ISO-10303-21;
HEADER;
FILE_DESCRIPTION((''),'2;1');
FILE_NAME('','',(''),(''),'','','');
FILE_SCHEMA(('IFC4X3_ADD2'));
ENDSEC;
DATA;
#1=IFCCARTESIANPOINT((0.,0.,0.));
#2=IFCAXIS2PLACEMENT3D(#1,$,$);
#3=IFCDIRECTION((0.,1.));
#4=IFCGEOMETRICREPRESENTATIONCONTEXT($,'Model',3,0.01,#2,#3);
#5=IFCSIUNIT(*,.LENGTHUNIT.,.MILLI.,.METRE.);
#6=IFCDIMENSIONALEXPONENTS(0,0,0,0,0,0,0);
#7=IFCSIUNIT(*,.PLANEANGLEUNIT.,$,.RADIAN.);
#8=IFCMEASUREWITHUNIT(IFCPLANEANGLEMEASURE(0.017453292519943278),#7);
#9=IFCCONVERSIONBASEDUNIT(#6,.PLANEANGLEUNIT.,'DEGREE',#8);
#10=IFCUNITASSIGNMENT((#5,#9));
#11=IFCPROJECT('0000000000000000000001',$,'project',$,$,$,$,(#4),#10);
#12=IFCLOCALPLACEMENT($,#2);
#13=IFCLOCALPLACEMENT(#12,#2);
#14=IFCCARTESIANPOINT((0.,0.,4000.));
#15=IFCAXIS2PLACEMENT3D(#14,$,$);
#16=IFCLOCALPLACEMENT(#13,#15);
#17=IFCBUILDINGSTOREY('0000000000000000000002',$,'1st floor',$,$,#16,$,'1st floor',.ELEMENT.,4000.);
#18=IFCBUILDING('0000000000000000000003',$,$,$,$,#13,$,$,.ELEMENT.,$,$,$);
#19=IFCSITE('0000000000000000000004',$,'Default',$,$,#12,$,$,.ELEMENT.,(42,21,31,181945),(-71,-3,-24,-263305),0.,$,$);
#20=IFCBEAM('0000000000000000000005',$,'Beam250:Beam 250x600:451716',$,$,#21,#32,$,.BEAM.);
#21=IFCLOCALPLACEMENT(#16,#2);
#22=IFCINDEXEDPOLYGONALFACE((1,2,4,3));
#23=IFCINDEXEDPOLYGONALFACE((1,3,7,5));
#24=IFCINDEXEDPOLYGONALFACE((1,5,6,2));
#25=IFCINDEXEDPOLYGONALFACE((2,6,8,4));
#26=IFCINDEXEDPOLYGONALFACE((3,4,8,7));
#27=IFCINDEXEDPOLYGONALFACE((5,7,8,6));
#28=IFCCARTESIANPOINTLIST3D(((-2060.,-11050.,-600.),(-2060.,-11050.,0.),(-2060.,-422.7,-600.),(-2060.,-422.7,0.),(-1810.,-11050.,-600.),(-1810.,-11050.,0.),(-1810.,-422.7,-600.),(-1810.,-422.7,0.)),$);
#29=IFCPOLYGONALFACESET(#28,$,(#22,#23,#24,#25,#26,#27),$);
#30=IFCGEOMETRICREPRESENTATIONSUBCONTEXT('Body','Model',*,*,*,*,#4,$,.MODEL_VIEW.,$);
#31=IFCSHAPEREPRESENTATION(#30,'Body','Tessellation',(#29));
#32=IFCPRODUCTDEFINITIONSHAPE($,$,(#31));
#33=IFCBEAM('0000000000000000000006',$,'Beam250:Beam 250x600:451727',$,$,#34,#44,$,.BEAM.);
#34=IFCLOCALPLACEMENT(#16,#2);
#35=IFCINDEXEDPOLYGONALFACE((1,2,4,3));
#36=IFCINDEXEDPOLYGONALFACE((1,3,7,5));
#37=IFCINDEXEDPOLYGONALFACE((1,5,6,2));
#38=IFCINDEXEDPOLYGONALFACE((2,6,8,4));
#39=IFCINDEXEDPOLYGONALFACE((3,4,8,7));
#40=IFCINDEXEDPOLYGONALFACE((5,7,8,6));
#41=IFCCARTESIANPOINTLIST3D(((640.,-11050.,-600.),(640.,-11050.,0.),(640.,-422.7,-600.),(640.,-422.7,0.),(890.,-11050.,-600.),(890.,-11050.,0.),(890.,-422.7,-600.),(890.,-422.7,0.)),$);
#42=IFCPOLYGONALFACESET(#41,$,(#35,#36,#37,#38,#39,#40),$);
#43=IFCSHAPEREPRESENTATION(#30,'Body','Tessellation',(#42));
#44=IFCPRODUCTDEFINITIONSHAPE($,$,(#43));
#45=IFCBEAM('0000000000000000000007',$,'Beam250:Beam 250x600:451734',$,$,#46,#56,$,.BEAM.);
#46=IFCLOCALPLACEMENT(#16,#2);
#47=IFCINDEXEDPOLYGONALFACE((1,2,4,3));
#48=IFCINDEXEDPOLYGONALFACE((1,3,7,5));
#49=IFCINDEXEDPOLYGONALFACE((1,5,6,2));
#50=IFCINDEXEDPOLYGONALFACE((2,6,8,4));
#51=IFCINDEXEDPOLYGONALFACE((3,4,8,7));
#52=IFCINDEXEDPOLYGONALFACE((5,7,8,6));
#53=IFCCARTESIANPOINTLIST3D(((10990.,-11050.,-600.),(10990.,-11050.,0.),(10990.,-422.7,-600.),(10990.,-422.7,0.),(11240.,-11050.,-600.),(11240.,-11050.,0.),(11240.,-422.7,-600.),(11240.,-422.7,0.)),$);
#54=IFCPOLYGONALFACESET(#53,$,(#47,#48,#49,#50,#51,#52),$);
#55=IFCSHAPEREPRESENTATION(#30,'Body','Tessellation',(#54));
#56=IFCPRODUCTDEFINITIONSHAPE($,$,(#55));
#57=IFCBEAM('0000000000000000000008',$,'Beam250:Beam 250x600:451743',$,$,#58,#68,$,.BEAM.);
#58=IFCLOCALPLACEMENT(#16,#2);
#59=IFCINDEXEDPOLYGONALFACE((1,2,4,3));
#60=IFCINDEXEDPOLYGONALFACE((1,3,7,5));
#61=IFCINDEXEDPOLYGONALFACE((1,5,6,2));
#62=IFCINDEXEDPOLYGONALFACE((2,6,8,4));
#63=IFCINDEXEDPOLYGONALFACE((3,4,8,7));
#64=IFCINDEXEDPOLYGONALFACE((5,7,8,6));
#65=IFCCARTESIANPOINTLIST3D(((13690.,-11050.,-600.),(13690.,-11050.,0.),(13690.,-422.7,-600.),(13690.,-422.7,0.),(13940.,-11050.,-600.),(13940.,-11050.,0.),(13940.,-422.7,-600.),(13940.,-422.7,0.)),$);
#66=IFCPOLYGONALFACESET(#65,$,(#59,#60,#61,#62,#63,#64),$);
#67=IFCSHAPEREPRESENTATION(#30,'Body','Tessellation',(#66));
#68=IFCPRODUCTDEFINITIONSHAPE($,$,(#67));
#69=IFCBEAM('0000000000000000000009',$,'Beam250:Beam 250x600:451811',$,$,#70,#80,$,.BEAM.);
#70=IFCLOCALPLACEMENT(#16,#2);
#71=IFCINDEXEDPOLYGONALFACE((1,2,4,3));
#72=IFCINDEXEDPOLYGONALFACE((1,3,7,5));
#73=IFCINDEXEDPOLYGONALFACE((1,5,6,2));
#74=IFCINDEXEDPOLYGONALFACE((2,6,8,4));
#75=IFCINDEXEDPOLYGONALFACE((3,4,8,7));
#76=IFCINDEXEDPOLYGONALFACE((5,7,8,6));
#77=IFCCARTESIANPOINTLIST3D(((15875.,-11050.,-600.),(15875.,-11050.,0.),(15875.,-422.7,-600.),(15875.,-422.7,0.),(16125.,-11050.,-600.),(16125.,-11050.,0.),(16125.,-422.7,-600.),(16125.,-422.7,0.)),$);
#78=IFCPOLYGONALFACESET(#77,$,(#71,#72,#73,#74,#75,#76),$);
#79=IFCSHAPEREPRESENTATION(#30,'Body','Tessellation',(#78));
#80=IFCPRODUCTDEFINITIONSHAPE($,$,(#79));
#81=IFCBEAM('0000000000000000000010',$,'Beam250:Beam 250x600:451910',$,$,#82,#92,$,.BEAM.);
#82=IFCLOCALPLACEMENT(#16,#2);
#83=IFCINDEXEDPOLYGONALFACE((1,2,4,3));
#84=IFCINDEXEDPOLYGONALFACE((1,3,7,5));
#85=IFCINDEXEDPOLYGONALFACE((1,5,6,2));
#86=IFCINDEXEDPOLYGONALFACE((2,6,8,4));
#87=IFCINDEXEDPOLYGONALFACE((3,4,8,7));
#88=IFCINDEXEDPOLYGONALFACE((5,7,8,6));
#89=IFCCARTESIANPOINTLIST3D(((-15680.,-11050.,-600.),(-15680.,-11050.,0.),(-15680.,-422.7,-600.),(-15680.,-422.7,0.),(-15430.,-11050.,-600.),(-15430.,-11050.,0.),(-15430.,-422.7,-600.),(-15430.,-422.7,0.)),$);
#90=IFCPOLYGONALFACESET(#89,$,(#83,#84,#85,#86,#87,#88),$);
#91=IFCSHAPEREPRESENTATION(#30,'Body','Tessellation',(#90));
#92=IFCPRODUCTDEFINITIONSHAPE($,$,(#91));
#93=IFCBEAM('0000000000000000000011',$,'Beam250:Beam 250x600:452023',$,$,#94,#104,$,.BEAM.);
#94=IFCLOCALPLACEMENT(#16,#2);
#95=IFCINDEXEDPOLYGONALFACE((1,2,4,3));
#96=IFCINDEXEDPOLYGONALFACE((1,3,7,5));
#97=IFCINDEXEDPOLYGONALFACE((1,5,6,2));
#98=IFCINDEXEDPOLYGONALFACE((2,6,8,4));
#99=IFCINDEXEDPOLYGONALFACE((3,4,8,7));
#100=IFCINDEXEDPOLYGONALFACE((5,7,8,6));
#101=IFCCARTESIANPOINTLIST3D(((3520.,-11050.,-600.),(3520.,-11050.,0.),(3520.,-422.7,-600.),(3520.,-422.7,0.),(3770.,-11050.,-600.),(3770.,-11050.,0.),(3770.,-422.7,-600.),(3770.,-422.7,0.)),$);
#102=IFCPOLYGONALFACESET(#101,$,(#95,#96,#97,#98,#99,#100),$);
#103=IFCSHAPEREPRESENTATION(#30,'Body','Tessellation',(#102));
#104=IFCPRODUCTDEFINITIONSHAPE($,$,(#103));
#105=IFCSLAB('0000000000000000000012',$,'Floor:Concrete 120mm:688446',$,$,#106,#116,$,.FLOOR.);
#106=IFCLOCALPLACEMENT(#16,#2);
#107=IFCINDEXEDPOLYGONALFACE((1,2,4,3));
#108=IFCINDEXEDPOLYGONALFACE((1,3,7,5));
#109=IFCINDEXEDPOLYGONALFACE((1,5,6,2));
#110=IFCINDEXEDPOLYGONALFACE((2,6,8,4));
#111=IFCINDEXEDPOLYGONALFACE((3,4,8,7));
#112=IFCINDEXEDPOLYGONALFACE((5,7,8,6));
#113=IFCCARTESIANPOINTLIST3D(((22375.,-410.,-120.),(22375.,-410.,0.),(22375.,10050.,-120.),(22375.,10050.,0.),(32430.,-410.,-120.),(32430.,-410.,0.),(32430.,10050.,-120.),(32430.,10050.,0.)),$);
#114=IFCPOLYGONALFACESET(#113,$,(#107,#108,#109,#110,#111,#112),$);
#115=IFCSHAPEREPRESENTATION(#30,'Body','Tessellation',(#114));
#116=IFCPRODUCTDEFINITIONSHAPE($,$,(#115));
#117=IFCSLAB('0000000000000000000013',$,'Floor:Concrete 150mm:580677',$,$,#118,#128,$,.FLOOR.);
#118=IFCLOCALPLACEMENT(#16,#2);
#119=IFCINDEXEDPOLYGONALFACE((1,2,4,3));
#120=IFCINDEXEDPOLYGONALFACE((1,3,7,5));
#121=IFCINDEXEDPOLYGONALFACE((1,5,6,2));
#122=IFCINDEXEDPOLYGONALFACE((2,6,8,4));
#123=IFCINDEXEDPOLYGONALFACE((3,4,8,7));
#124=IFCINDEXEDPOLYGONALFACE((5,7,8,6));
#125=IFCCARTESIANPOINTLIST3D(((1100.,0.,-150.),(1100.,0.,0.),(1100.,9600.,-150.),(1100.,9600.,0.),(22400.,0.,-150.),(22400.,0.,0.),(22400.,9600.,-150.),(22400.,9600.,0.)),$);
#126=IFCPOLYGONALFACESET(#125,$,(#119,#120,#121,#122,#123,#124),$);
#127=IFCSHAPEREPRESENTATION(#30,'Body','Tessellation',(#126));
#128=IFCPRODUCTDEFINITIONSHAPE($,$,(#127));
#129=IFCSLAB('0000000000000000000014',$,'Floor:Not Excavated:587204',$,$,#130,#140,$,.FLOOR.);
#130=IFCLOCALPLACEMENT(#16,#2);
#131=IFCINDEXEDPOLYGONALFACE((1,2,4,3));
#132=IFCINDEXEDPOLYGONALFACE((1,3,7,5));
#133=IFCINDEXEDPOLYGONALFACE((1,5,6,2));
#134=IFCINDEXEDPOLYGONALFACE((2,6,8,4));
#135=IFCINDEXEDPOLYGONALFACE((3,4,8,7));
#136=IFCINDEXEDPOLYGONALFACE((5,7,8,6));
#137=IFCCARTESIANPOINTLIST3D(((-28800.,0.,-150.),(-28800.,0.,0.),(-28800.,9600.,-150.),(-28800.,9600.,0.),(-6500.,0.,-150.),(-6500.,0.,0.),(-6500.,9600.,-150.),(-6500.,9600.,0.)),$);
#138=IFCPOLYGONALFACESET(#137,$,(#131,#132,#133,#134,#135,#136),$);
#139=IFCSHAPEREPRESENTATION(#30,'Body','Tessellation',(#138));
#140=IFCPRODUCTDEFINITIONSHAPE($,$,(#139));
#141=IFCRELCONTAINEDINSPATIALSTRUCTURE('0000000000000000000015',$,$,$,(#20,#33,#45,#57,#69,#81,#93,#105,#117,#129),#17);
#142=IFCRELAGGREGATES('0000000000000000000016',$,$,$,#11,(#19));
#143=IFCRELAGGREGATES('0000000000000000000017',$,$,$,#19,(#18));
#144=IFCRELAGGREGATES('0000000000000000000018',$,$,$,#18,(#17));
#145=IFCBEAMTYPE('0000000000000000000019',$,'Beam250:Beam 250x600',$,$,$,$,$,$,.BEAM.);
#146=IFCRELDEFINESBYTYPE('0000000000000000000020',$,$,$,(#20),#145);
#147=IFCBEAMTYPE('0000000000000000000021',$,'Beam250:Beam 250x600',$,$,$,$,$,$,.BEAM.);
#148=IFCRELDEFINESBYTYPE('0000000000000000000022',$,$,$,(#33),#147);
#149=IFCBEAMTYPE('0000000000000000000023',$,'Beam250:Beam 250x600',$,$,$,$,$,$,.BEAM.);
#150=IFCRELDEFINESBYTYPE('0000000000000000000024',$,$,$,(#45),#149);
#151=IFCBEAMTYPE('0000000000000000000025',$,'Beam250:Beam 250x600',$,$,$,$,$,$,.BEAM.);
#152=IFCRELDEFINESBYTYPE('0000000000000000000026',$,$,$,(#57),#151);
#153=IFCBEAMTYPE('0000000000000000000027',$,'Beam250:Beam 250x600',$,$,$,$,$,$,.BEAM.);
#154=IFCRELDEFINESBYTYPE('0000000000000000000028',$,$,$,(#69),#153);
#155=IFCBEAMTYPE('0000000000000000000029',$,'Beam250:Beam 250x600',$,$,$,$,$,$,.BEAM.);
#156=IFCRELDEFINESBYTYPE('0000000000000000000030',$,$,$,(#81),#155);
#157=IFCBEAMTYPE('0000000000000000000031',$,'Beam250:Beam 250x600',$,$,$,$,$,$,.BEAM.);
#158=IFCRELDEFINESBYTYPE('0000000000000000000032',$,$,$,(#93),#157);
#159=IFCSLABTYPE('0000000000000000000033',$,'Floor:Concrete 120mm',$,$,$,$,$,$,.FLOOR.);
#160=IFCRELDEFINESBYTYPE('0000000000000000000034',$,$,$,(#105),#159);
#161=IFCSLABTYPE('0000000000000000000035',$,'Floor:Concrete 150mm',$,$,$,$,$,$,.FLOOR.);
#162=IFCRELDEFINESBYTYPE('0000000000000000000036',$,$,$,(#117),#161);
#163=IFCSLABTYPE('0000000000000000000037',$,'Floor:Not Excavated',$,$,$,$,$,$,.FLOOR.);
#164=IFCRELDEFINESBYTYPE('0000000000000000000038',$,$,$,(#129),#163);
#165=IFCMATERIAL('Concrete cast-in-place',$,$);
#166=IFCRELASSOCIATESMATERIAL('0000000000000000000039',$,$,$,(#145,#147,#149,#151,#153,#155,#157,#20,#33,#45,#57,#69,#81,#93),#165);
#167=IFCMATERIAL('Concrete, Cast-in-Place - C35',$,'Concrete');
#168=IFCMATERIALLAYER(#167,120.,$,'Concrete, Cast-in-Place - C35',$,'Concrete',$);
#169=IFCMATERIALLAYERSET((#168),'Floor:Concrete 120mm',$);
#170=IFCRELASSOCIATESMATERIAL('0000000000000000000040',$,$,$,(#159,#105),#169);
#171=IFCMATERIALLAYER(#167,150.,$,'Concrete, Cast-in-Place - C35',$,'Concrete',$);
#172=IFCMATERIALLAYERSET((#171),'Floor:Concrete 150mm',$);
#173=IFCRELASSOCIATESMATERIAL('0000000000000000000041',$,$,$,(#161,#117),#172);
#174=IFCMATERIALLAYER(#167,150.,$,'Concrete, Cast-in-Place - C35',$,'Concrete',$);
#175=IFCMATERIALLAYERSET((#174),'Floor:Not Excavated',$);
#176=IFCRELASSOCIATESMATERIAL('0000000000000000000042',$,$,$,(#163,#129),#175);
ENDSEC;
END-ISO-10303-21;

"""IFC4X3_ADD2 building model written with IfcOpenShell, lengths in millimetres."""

from ifc_helpers import new_model, entity, si_unit, converted_unit, direction, frame, frame_2d, origin, origin_2d_with_axis, place, context, subcontext, project, spatial, rectangle, extrude, source, transform, mapped, material, layer, layer_set, layer_usage, material_profile, profile_set, profile_usage, type_object, type_shapes, element, save


model = new_model("IFC4X3_ADD2")

# Units and contexts
model_context = context("Model", 3, precision=0.01, world=origin(), true_north=direction((0.0, 1.0)))
body_context = subcontext(model_context, "Body", "Model", "MODEL_VIEW")
ifc_project = project(units=[si_unit("LENGTHUNIT", "METRE", prefix="MILLI"), converted_unit("PLANEANGLEUNIT", "DEGREE", entity("IfcPlaneAngleMeasure", 0.017453292519943278), si_unit("PLANEANGLEUNIT", "RADIAN"), dimensions=[0, 0, 0, 0, 0, 0, 0])], contexts=[model_context])

# Site, building, storey
site_placement = place(None, origin())
site = spatial("IfcSite", under=ifc_project, at=site_placement, Name="Default", CompositionType="ELEMENT", RefLatitude=(42, 21, 31, 181945), RefLongitude=(-71, -3, -24, -263305), RefElevation=0.0)
building_placement = place(site_placement, origin())
building = spatial("IfcBuilding", under=site, at=building_placement, CompositionType="ELEMENT")
storey_placement = place(building_placement, frame((0.0, 0.0, 4000.0)))
storey = spatial("IfcBuildingStorey", under=building, at=storey_placement, Name="1st floor", LongName="1st floor", CompositionType="ELEMENT", Elevation=4000.0)

# Shared definitions
ifc_material_1 = material(Name="Concrete, Cast-in-Place - C35", Category="Concrete")

# Beams
ifc_material_2 = material(Name="Concrete cast-in-place")
ifc_material_profile_1 = material_profile(ifc_material_2, rectangle(XDim=600.0, YDim=250.0, at=frame_2d((0.0, 0.0), x_axis=(0.0, 1.0))), Name="Beam 250x600")
ifc_profile_set_1 = profile_set([ifc_material_profile_1], Name="Beam 250x600")
ifc_profile_usage_1 = profile_usage(ifc_profile_set_1, cardinal=8)
beam_type_1 = type_object("IfcBeamType", Name="Beam250:Beam 250x600", PredefinedType="BEAM", material=ifc_profile_set_1)
shared_shape_1 = source(origin(), body_context, "Body", "SweptSolid", [
    extrude(rectangle(XDim=600.0, YDim=250.0, at=frame_2d((0.0, 0.0), x_axis=(0.0, 1.0))), frame((-1935.0, -11050.0, 3700.0), z_axis=(0.0, 1.0, 0.0), x_axis=(-1.0, 0.0, 0.0)), (0.0, 0.0, 1.0), 10627.3),
])
type_shapes(beam_type_1, [shared_shape_1])
beam_1_placement = place(storey_placement, frame((0.0, 0.0, -4000.0)))
element("IfcBeam", 1, at=beam_1_placement, inside=storey, type_object=beam_type_1, material=ifc_profile_usage_1, Name="Beam250:Beam 250x600:451716", PredefinedType="BEAM", context=body_context, shape_type="MappedRepresentation", body=[
    mapped(shared_shape_1, transform((0.0, 0.0, 0.0), scale=1.0)),
])
beam_type_2 = type_object("IfcBeamType", Name="Beam250:Beam 250x600", PredefinedType="BEAM", material=ifc_profile_set_1)
shared_shape_2 = source(origin(), body_context, "Body", "SweptSolid", [
    extrude(rectangle(XDim=600.0, YDim=250.0, at=frame_2d((0.0, 0.0), x_axis=(0.0, 1.0))), frame((765.0, -11050.0, 3700.0), z_axis=(0.0, 1.0, 0.0), x_axis=(-1.0, 0.0, 0.0)), (0.0, 0.0, 1.0), 10627.3),
])
type_shapes(beam_type_2, [shared_shape_2])
beam_2_placement = place(storey_placement, frame((0.0, 0.0, -4000.0)))
element("IfcBeam", 2, at=beam_2_placement, inside=storey, type_object=beam_type_2, material=ifc_profile_usage_1, Name="Beam250:Beam 250x600:451727", PredefinedType="BEAM", context=body_context, shape_type="MappedRepresentation", body=[
    mapped(shared_shape_2, transform((0.0, 0.0, 0.0), scale=1.0)),
])
beam_type_3 = type_object("IfcBeamType", Name="Beam250:Beam 250x600", PredefinedType="BEAM", material=ifc_profile_set_1)
shared_shape_3 = source(origin(), body_context, "Body", "SweptSolid", [
    extrude(rectangle(XDim=600.0, YDim=250.0, at=frame_2d((0.0, 0.0), x_axis=(0.0, 1.0))), frame((11115.0, -11050.0, 3700.0), z_axis=(0.0, 1.0, 0.0), x_axis=(-1.0, 0.0, 0.0)), (0.0, 0.0, 1.0), 10627.3),
])
type_shapes(beam_type_3, [shared_shape_3])
beam_3_placement = place(storey_placement, frame((0.0, 0.0, -4000.0)))
element("IfcBeam", 3, at=beam_3_placement, inside=storey, type_object=beam_type_3, material=ifc_profile_usage_1, Name="Beam250:Beam 250x600:451734", PredefinedType="BEAM", context=body_context, shape_type="MappedRepresentation", body=[
    mapped(shared_shape_3, transform((0.0, 0.0, 0.0), scale=1.0)),
])
beam_type_4 = type_object("IfcBeamType", Name="Beam250:Beam 250x600", PredefinedType="BEAM", material=ifc_profile_set_1)
shared_shape_4 = source(origin(), body_context, "Body", "SweptSolid", [
    extrude(rectangle(XDim=600.0, YDim=250.0, at=frame_2d((0.0, 0.0), x_axis=(0.0, 1.0))), frame((13815.0, -11050.0, 3700.0), z_axis=(0.0, 1.0, 0.0), x_axis=(-1.0, 0.0, 0.0)), (0.0, 0.0, 1.0), 10627.3),
])
type_shapes(beam_type_4, [shared_shape_4])
beam_4_placement = place(storey_placement, frame((0.0, 0.0, -4000.0)))
element("IfcBeam", 4, at=beam_4_placement, inside=storey, type_object=beam_type_4, material=ifc_profile_usage_1, Name="Beam250:Beam 250x600:451743", PredefinedType="BEAM", context=body_context, shape_type="MappedRepresentation", body=[
    mapped(shared_shape_4, transform((0.0, 0.0, 0.0), scale=1.0)),
])
beam_type_5 = type_object("IfcBeamType", Name="Beam250:Beam 250x600", PredefinedType="BEAM", material=ifc_profile_set_1)
shared_shape_5 = source(origin(), body_context, "Body", "SweptSolid", [
    extrude(rectangle(XDim=600.0, YDim=250.0, at=frame_2d((0.0, 0.0), x_axis=(0.0, 1.0))), frame((16000.0, -11050.0, 3700.0), z_axis=(0.0, 1.0, 0.0), x_axis=(-1.0, 0.0, 0.0)), (0.0, 0.0, 1.0), 10627.3),
])
type_shapes(beam_type_5, [shared_shape_5])
beam_5_placement = place(storey_placement, frame((0.0, 0.0, -4000.0)))
element("IfcBeam", 5, at=beam_5_placement, inside=storey, type_object=beam_type_5, material=ifc_profile_usage_1, Name="Beam250:Beam 250x600:451811", PredefinedType="BEAM", context=body_context, shape_type="MappedRepresentation", body=[
    mapped(shared_shape_5, transform((0.0, 0.0, 0.0), scale=1.0)),
])
beam_type_6 = type_object("IfcBeamType", Name="Beam250:Beam 250x600", PredefinedType="BEAM", material=ifc_profile_set_1)
shared_shape_6 = source(origin(), body_context, "Body", "SweptSolid", [
    extrude(rectangle(XDim=600.0, YDim=250.0, at=frame_2d((0.0, 0.0), x_axis=(0.0, 1.0))), frame((-15555.0, -11050.0, 3700.0), z_axis=(0.0, 1.0, 0.0), x_axis=(-1.0, 0.0, 0.0)), (0.0, 0.0, 1.0), 10627.3),
])
type_shapes(beam_type_6, [shared_shape_6])
beam_6_placement = place(storey_placement, frame((0.0, 0.0, -4000.0)))
element("IfcBeam", 6, at=beam_6_placement, inside=storey, type_object=beam_type_6, material=ifc_profile_usage_1, Name="Beam250:Beam 250x600:451910", PredefinedType="BEAM", context=body_context, shape_type="MappedRepresentation", body=[
    mapped(shared_shape_6, transform((0.0, 0.0, 0.0), scale=1.0)),
])
beam_type_7 = type_object("IfcBeamType", Name="Beam250:Beam 250x600", PredefinedType="BEAM", material=ifc_profile_set_1)
shared_shape_7 = source(origin(), body_context, "Body", "SweptSolid", [
    extrude(rectangle(XDim=600.0, YDim=250.0, at=frame_2d((0.0, 0.0), x_axis=(0.0, 1.0))), frame((3645.0, -11050.0, 3700.0), z_axis=(0.0, 1.0, 0.0), x_axis=(-1.0, 0.0, 0.0)), (0.0, 0.0, 1.0), 10627.3),
])
type_shapes(beam_type_7, [shared_shape_7])
beam_7_placement = place(storey_placement, frame((0.0, 0.0, -4000.0)))
element("IfcBeam", 7, at=beam_7_placement, inside=storey, type_object=beam_type_7, material=ifc_profile_usage_1, Name="Beam250:Beam 250x600:452023", PredefinedType="BEAM", context=body_context, shape_type="MappedRepresentation", body=[
    mapped(shared_shape_7, transform((0.0, 0.0, 0.0), scale=1.0)),
])

# Slabs
ifc_layer_1 = layer(ifc_material_1, 120.0, Name="Concrete, Cast-in-Place - C35", Category="Concrete")
ifc_layer_set_1 = layer_set([ifc_layer_1], Name="Floor:Concrete 120mm")
ifc_layer_usage_1 = layer_usage(ifc_layer_set_1, "AXIS3", "POSITIVE", 0.0)
slab_type_1 = type_object("IfcSlabType", Name="Floor:Concrete 120mm", PredefinedType="FLOOR", material=ifc_layer_set_1)
slab_1_placement = place(storey_placement, origin())
element("IfcSlab", 8, at=slab_1_placement, inside=storey, type_object=slab_type_1, material=ifc_layer_usage_1, Name="Floor:Concrete 120mm:688446", PredefinedType="FLOOR", context=body_context, shape_type="SweptSolid", body=[
    extrude(rectangle(XDim=10460.0, YDim=10055.0, at=frame_2d((0.0, 0.0), x_axis=(1.0, 0.0))), frame((27402.5, 4820.0, 0.0), z_axis=(0.0, 0.0, -1.0), x_axis=(0.0, 1.0, 0.0)), (0.0, 0.0, 1.0), 120.0),
])
ifc_layer_2 = layer(ifc_material_1, 150.0, Name="Concrete, Cast-in-Place - C35", Category="Concrete")
ifc_layer_set_2 = layer_set([ifc_layer_2], Name="Floor:Concrete 150mm")
ifc_layer_usage_2 = layer_usage(ifc_layer_set_2, "AXIS3", "POSITIVE", 0.0)
slab_type_2 = type_object("IfcSlabType", Name="Floor:Concrete 150mm", PredefinedType="FLOOR", material=ifc_layer_set_2)
slab_2_placement = place(storey_placement, origin())
element("IfcSlab", 9, at=slab_2_placement, inside=storey, type_object=slab_type_2, material=ifc_layer_usage_2, Name="Floor:Concrete 150mm:580677", PredefinedType="FLOOR", context=body_context, shape_type="SweptSolid", body=[
    extrude(rectangle(XDim=9600.0, YDim=21300.0, at=origin_2d_with_axis()), frame((11750.0, 4800.0, 0.0), z_axis=(0.0, 0.0, -1.0), x_axis=(0.0, 1.0, 0.0)), (0.0, 0.0, 1.0), 150.0),
])
ifc_layer_3 = layer(ifc_material_1, 150.0, Name="Concrete, Cast-in-Place - C35", Category="Concrete")
ifc_layer_set_3 = layer_set([ifc_layer_3], Name="Floor:Not Excavated")
ifc_layer_usage_3 = layer_usage(ifc_layer_set_3, "AXIS3", "POSITIVE", 0.0)
slab_type_3 = type_object("IfcSlabType", Name="Floor:Not Excavated", PredefinedType="FLOOR", material=ifc_layer_set_3)
slab_3_placement = place(storey_placement, origin())
element("IfcSlab", 10, at=slab_3_placement, inside=storey, type_object=slab_type_3, material=ifc_layer_usage_3, Name="Floor:Not Excavated:587204", PredefinedType="FLOOR", context=body_context, shape_type="SweptSolid", body=[
    extrude(rectangle(XDim=9600.0, YDim=22300.0, at=origin_2d_with_axis()), frame((-17650.0, 4800.0, 0.0), z_axis=(0.0, 0.0, -1.0), x_axis=(0.0, 1.0, 0.0)), (0.0, 0.0, 1.0), 150.0),
])

save(model, "model.ifc")
